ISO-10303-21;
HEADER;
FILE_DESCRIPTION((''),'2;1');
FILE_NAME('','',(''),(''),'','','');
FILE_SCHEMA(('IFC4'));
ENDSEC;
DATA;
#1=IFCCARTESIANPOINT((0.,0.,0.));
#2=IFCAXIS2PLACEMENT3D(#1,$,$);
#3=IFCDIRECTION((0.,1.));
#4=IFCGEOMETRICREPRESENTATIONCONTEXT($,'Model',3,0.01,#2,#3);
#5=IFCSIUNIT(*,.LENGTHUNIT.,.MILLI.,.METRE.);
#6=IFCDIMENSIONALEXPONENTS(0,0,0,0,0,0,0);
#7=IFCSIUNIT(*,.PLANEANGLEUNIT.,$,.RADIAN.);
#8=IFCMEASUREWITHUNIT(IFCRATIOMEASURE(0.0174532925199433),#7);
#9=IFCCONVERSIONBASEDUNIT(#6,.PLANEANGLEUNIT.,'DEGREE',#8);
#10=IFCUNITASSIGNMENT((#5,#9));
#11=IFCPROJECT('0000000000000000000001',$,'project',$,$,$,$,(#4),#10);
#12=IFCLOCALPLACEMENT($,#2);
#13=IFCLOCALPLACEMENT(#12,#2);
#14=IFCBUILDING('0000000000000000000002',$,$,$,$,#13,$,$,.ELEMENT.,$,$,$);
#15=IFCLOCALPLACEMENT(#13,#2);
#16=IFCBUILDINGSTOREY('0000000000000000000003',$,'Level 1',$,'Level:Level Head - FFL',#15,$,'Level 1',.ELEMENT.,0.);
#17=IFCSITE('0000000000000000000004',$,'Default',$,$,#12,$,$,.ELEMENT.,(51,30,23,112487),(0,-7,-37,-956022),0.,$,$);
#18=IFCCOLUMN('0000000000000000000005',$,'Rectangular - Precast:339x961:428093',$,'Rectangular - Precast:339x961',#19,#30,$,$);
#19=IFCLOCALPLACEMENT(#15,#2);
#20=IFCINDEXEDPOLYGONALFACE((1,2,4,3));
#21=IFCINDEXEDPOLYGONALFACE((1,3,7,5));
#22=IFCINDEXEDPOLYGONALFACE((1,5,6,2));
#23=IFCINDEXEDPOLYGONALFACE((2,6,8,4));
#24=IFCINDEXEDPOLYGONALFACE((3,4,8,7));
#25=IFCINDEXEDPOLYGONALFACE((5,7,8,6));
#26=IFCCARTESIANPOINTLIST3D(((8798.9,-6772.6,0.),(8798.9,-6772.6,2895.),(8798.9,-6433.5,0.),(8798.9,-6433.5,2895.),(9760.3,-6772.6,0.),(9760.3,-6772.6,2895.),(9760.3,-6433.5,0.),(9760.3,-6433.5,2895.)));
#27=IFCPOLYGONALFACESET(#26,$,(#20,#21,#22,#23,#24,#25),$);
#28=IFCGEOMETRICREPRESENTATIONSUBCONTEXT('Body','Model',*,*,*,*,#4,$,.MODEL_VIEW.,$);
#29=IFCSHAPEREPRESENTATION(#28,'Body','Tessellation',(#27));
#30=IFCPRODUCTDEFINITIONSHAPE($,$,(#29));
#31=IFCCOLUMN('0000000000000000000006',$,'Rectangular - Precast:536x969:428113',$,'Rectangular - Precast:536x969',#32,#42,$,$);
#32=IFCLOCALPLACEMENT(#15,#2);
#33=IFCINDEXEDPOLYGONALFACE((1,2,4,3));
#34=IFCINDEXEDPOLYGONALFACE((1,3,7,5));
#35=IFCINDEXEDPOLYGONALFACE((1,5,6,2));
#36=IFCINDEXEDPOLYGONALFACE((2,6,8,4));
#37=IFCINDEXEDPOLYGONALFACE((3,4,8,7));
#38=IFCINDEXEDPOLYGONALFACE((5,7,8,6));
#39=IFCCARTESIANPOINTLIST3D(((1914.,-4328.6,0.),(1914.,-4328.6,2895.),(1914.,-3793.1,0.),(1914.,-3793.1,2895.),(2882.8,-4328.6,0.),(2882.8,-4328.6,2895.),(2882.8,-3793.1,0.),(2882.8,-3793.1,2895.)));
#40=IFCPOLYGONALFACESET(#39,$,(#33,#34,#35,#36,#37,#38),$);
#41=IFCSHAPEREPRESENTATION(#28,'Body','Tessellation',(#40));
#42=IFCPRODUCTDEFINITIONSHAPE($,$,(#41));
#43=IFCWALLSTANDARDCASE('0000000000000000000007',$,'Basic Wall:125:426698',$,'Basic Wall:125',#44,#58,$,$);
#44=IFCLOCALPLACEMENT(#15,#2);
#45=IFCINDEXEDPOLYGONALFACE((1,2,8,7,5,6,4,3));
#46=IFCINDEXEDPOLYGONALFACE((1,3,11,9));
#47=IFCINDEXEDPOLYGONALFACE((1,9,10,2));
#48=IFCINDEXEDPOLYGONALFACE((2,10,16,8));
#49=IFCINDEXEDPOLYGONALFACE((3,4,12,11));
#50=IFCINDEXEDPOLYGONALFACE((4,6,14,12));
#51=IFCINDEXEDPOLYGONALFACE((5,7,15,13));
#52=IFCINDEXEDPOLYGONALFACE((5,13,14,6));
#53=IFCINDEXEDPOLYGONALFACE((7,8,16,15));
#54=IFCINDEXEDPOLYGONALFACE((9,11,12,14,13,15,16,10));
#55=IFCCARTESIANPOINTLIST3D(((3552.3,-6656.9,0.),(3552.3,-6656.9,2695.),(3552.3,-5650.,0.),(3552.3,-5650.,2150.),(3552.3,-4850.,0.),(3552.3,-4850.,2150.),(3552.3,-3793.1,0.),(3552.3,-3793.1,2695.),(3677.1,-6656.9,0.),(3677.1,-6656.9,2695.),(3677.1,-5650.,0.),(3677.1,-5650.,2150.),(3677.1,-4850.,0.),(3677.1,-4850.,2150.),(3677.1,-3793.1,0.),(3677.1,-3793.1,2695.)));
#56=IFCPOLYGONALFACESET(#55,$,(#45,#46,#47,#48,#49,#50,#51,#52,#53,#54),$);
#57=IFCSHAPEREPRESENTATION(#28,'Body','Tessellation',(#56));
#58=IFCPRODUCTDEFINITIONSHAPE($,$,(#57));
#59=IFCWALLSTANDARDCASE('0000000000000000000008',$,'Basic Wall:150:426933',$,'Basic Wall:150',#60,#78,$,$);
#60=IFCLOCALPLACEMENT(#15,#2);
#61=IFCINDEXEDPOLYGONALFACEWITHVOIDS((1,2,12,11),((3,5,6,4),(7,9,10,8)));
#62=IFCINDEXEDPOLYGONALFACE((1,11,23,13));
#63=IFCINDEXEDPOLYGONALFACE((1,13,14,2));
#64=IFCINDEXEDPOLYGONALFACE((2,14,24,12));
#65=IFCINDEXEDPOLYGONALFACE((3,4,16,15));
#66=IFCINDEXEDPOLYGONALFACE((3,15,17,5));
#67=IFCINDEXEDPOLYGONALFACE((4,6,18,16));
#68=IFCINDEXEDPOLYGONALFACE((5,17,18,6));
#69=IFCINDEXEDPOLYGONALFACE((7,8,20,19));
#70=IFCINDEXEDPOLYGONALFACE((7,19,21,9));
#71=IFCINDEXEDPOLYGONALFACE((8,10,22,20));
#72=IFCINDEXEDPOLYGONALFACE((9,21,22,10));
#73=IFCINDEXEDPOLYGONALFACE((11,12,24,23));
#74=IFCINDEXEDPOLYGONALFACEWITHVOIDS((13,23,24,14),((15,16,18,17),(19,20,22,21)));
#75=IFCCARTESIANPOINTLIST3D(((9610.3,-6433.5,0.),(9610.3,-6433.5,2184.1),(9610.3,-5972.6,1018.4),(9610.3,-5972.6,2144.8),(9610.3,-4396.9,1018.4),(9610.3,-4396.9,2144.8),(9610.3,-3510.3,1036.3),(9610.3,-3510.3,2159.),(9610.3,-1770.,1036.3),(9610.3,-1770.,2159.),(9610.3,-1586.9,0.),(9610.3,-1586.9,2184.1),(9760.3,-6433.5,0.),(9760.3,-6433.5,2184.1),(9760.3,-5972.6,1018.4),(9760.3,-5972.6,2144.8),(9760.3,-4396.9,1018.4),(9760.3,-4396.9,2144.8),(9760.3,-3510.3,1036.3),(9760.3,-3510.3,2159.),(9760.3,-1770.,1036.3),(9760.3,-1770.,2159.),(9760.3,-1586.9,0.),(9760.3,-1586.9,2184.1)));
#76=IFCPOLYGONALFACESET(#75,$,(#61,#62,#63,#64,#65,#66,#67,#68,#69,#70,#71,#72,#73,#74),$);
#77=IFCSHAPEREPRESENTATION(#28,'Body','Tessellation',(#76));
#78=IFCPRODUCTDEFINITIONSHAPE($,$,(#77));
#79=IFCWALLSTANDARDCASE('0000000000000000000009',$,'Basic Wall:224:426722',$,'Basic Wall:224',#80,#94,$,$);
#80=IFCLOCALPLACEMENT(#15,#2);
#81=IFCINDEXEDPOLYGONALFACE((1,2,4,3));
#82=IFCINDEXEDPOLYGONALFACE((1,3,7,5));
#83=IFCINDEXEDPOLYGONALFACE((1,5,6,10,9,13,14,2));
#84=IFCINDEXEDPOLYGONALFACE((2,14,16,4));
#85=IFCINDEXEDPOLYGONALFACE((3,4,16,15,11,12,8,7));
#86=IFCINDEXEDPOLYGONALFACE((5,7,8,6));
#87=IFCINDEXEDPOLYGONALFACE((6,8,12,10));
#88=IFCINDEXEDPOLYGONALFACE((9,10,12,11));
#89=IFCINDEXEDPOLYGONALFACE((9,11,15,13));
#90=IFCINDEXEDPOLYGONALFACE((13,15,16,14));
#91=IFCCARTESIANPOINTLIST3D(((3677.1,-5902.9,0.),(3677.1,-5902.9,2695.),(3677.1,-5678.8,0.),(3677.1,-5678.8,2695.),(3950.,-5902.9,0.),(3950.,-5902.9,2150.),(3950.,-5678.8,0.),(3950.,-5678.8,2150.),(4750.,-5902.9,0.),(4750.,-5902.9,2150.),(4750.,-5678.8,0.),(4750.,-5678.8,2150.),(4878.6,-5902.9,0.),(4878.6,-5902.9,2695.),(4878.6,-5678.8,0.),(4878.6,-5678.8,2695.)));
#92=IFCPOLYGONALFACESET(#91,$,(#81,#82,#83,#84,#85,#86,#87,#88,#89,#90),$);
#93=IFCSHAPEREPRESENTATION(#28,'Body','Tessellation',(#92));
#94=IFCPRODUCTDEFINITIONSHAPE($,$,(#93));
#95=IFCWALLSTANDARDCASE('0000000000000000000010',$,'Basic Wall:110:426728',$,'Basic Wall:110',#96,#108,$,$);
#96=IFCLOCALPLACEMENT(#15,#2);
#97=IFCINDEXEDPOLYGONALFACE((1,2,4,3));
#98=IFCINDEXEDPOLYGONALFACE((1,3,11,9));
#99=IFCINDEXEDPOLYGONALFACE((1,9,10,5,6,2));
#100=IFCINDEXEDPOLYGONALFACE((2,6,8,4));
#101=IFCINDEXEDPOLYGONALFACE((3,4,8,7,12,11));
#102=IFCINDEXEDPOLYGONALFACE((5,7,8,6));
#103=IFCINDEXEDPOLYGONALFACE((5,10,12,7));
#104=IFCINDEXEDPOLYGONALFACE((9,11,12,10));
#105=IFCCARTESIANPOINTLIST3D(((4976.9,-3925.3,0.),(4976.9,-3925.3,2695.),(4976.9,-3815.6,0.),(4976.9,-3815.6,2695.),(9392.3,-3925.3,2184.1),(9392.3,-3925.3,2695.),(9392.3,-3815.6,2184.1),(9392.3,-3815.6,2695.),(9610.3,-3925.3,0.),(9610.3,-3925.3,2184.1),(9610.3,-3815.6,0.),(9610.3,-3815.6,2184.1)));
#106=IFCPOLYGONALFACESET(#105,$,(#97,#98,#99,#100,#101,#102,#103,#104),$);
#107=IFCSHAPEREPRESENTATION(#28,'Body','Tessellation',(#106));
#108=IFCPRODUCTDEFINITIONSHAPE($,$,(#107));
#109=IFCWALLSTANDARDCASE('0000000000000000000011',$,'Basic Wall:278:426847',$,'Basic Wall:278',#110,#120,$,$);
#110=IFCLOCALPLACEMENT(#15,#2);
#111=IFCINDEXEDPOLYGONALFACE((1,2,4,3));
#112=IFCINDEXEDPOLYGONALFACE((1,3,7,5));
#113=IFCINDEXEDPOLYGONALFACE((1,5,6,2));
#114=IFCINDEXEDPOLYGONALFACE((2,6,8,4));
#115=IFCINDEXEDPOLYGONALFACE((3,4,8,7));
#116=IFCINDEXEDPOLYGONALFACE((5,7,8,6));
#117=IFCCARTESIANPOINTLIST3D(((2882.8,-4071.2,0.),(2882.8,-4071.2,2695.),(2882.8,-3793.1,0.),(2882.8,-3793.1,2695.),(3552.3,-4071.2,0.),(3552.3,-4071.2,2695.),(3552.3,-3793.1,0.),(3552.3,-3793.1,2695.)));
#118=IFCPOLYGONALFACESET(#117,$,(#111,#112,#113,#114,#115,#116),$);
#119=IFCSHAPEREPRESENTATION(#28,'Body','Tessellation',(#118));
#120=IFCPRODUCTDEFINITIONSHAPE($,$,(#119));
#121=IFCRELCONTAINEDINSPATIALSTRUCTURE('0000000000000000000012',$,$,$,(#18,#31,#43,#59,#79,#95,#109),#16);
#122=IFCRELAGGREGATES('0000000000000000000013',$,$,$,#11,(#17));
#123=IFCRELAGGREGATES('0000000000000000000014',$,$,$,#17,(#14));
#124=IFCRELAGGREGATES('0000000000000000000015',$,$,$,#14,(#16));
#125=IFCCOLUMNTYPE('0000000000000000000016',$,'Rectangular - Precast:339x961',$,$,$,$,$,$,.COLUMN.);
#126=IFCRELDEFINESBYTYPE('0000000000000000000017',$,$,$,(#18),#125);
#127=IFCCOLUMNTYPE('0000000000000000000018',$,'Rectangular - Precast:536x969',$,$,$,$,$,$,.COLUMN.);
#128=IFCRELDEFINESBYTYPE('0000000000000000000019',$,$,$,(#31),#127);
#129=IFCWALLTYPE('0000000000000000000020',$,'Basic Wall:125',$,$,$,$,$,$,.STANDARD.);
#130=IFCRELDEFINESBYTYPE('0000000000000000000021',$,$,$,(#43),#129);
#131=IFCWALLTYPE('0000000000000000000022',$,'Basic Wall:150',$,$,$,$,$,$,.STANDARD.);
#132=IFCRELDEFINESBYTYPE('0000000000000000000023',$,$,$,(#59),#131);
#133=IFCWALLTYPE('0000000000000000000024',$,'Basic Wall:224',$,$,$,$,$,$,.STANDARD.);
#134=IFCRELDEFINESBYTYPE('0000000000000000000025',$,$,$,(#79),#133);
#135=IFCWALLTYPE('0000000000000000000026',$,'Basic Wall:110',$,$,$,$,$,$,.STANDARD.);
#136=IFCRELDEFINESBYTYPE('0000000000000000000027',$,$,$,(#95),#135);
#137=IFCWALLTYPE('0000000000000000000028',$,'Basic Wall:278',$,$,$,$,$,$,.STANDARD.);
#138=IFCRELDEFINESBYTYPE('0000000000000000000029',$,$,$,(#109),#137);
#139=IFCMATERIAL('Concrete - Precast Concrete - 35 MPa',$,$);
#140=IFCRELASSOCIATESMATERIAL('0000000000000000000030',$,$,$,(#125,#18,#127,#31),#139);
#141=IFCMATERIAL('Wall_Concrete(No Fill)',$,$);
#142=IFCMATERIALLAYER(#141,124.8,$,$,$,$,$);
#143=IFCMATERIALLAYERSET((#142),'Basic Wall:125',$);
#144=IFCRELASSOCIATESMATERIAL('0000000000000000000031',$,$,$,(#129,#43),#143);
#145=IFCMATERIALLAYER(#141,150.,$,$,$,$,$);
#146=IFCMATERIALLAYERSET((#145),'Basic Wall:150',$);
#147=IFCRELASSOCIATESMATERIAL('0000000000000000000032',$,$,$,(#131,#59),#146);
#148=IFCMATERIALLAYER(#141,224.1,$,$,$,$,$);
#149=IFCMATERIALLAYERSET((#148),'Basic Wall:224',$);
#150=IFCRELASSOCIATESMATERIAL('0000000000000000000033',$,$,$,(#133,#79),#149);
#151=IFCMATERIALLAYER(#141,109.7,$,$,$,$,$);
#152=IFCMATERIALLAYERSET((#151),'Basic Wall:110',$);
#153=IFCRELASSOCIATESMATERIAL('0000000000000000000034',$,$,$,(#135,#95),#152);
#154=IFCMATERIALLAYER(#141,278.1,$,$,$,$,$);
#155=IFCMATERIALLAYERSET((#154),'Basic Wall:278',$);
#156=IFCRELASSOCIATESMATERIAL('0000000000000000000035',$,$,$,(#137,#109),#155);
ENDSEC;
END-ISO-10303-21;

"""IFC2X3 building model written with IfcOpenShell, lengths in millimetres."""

from ifc_helpers import new_model, entity, si_unit, converted_unit, direction, frame, frame_2d, origin, origin_2d_with_axis, place, context, subcontext, project, spatial, rectangle, extrude, source, transform, mapped, material, layer, layer_set, layer_usage, type_object, type_shapes, element, save


model = new_model("IFC2X3")

# Units and contexts
model_context = context("Model", 3, precision=0.01, world=origin(), true_north=direction((0.0, 1.0)))
body_context = subcontext(model_context, "Body", "Model", "MODEL_VIEW")
ifc_project = project(units=[si_unit("LENGTHUNIT", "METRE", prefix="MILLI"), converted_unit("PLANEANGLEUNIT", "DEGREE", entity("IfcRatioMeasure", 0.0174532925199433), si_unit("PLANEANGLEUNIT", "RADIAN"), dimensions=[0, 0, 0, 0, 0, 0, 0])], contexts=[model_context])

# Site, building, storey
site_placement = place(None, origin())
site = spatial("IfcSite", under=ifc_project, at=site_placement, Name="Default", CompositionType="ELEMENT", RefLatitude=(51, 30, 23, 112487), RefLongitude=(0, -7, -37, -956022), RefElevation=0.0)
building_placement = place(site_placement, origin())
building = spatial("IfcBuilding", under=site, at=building_placement, CompositionType="ELEMENT")
storey_placement = place(building_placement, origin())
storey = spatial("IfcBuildingStorey", under=building, at=storey_placement, Name="Level 1", ObjectType="Level:Level Head - FFL", LongName="Level 1", CompositionType="ELEMENT", Elevation=0.0)

# Columns
ifc_material_1 = material(Name="Concrete - Precast Concrete - 35 MPa")
column_type_1 = type_object("IfcColumnType", Name="Rectangular - Precast:339x961", PredefinedType="COLUMN", material=ifc_material_1)
shared_shape_1 = source(origin(), body_context, "Body", "SweptSolid", [
    extrude(rectangle(XDim=961.4, YDim=339.0, at=frame_2d((0.0, 0.0), x_axis=(1.0, 0.0))), frame((0.0, 0.0, 0.0), z_axis=(0.0, 0.0, 1.0), x_axis=(0.0, -1.0, 0.0)), (0.0, 0.0, 1.0), 2895.0),
])
type_shapes(column_type_1, [shared_shape_1])
column_1_placement = place(storey_placement, frame((9279.6, -6603.1, 0.0), z_axis=(0.0, 0.0, 1.0), x_axis=(-0.000004, 1.0, 0.0)))
element("IfcColumn", 1, at=column_1_placement, inside=storey, type_object=column_type_1, material=ifc_material_1, Name="Rectangular - Precast:339x961:428093", ObjectType="Rectangular - Precast:339x961", context=body_context, shape_type="MappedRepresentation", body=[
    mapped(shared_shape_1, transform((0.0, 0.0, 0.0), scale=1.0)),
])
column_type_2 = type_object("IfcColumnType", Name="Rectangular - Precast:536x969", PredefinedType="COLUMN", material=ifc_material_1)
shared_shape_2 = source(origin(), body_context, "Body", "SweptSolid", [
    extrude(rectangle(XDim=968.8, YDim=535.5, at=frame_2d((0.0, 0.0), x_axis=(1.0, 0.0))), frame((0.0, 0.0, 0.0), z_axis=(0.0, 0.0, 1.0), x_axis=(0.0, -1.0, 0.0)), (0.0, 0.0, 1.0), 2895.0),
])
type_shapes(column_type_2, [shared_shape_2])
column_2_placement = place(storey_placement, frame((2398.4, -4060.9, 0.0), z_axis=(0.0, 0.0, 1.0), x_axis=(-0.000004, 1.0, 0.0)))
element("IfcColumn", 2, at=column_2_placement, inside=storey, type_object=column_type_2, material=ifc_material_1, Name="Rectangular - Precast:536x969:428113", ObjectType="Rectangular - Precast:536x969", context=body_context, shape_type="MappedRepresentation", body=[
    mapped(shared_shape_2, transform((0.0, 0.0, 0.0), scale=1.0)),
])

# Shared definitions
ifc_material_2 = material(Name="Wall_Concrete(No Fill)")

# Wall, opening
ifc_layer_1 = layer(ifc_material_2, 124.8)
ifc_layer_set_1 = layer_set([ifc_layer_1], Name="Basic Wall:125")
ifc_layer_usage_1 = layer_usage(ifc_layer_set_1, "AXIS2", "NEGATIVE", 62.4)
wall_type_1 = type_object("IfcWallType", Name="Basic Wall:125", PredefinedType="STANDARD", material=ifc_layer_set_1)
wall_1_placement = place(storey_placement, frame((3614.7, -6656.9, 0.0), z_axis=(0.0, 0.0, 1.0), x_axis=(0.0, 1.0, 0.0)))
wall_1 = element("IfcWallStandardCase", 3, at=wall_1_placement, inside=storey, type_object=wall_type_1, material=ifc_layer_usage_1, Name="Basic Wall:125:426698", ObjectType="Basic Wall:125", context=body_context, shape_type="SweptSolid", body=[
    extrude(rectangle(XDim=2863.8, YDim=124.8, at=frame_2d((1431.9, 0.0), x_axis=(-1.0, 0.0))), origin(), (0.0, 0.0, 1.0), 2695.0),
])
opening_1_placement = place(wall_1_placement, origin())
element("IfcOpeningElement", 4, at=opening_1_placement, cuts=wall_1, ObjectType="Opening", context=body_context, shape_type="SweptSolid", body=[
    extrude(rectangle(XDim=2150.0, YDim=800.0, at=frame_2d((0.0, 0.0), x_axis=(1.0, 0.0))), frame((1406.9, -62.4, 1075.0), z_axis=(0.0, 1.0, 0.0), x_axis=(0.0, 0.0, -1.0)), (0.0, 0.0, 1.0), 124.8),
])

# Wall, openings
ifc_layer_2 = layer(ifc_material_2, 150.0)
ifc_layer_set_2 = layer_set([ifc_layer_2], Name="Basic Wall:150")
wall_type_2 = type_object("IfcWallType", Name="Basic Wall:150", PredefinedType="STANDARD", material=ifc_layer_set_2)
ifc_layer_usage_2 = layer_usage(ifc_layer_set_2, "AXIS2", "NEGATIVE", 75.0)
wall_2_placement = place(storey_placement, frame((9685.3, -6433.5, 0.0), z_axis=(0.0, 0.0, 1.0), x_axis=(0.0, 1.0, 0.0)))
wall_2 = element("IfcWallStandardCase", 5, at=wall_2_placement, inside=storey, type_object=wall_type_2, material=ifc_layer_usage_2, Name="Basic Wall:150:426933", ObjectType="Basic Wall:150", context=body_context, shape_type="SweptSolid", body=[
    extrude(rectangle(XDim=4846.6, YDim=150.0, at=frame_2d((2423.3, 0.0), x_axis=(-1.0, 0.0))), origin(), (0.0, 0.0, 1.0), 2184.1),
])
opening_2_placement = place(wall_2_placement, origin())
element("IfcOpeningElement", 6, at=opening_2_placement, cuts=wall_2, ObjectType="Opening", context=body_context, shape_type="SweptSolid", body=[
    extrude(rectangle(XDim=710.9, YDim=4846.6, at=origin_2d_with_axis()), frame((2423.3, -75.0, 2539.6), z_axis=(0.0, 1.0, 0.0), x_axis=(0.0, 0.0, -1.0)), (0.0, 0.0, 1.0), 150.0),
])
opening_3_placement = place(wall_2_placement, origin())
element("IfcOpeningElement", 7, at=opening_3_placement, cuts=wall_2, ObjectType="Opening", context=body_context, shape_type="SweptSolid", body=[
    extrude(rectangle(XDim=1122.7, YDim=1740.3, at=origin_2d_with_axis()), frame((3793.4, -75.0, 1597.7), z_axis=(0.0, 1.0, 0.0), x_axis=(0.0, 0.0, -1.0)), (0.0, 0.0, 1.0), 150.0),
])
opening_4_placement = place(wall_2_placement, origin())
element("IfcOpeningElement", 8, at=opening_4_placement, cuts=wall_2, ObjectType="Opening", context=body_context, shape_type="SweptSolid", body=[
    extrude(rectangle(XDim=1126.4, YDim=1575.7, at=frame_2d((0.0, 0.0), x_axis=(1.0, 0.0))), frame((1248.8, -75.0, 1581.6), z_axis=(0.0, 1.0, 0.0), x_axis=(0.0, 0.0, -1.0)), (0.0, 0.0, 1.0), 150.0),
])

# Walls, openings
ifc_layer_3 = layer(ifc_material_2, 224.1)
ifc_layer_set_3 = layer_set([ifc_layer_3], Name="Basic Wall:224")
ifc_layer_usage_3 = layer_usage(ifc_layer_set_3, "AXIS2", "NEGATIVE", 112.0)
wall_type_3 = type_object("IfcWallType", Name="Basic Wall:224", PredefinedType="STANDARD", material=ifc_layer_set_3)
wall_3_placement = place(storey_placement, frame((3677.1, -5790.9, 0.0)))
wall_3 = element("IfcWallStandardCase", 9, at=wall_3_placement, inside=storey, type_object=wall_type_3, material=ifc_layer_usage_3, Name="Basic Wall:224:426722", ObjectType="Basic Wall:224", context=body_context, shape_type="SweptSolid", body=[
    extrude(rectangle(XDim=1201.5, YDim=224.1, at=frame_2d((600.7, 0.0), x_axis=(-1.0, 0.0))), origin(), (0.0, 0.0, 1.0), 2695.0),
])
opening_5_placement = place(wall_3_placement, origin())
element("IfcOpeningElement", 10, at=opening_5_placement, cuts=wall_3, ObjectType="Opening", context=body_context, shape_type="SweptSolid", body=[
    extrude(rectangle(XDim=2150.0, YDim=800.0, at=frame_2d((0.0, 0.0), x_axis=(1.0, 0.0))), frame((672.9, -112.0, 1075.0), z_axis=(0.0, 1.0, 0.0), x_axis=(0.0, 0.0, -1.0)), (0.0, 0.0, 1.0), 224.1),
])
ifc_layer_4 = layer(ifc_material_2, 109.7)
ifc_layer_set_4 = layer_set([ifc_layer_4], Name="Basic Wall:110")
ifc_layer_usage_4 = layer_usage(ifc_layer_set_4, "AXIS2", "NEGATIVE", 54.8)
wall_type_4 = type_object("IfcWallType", Name="Basic Wall:110", PredefinedType="STANDARD", material=ifc_layer_set_4)
wall_4_placement = place(storey_placement, frame((4976.9, -3870.5, 0.0)))
wall_4 = element("IfcWallStandardCase", 11, at=wall_4_placement, inside=storey, type_object=wall_type_4, material=ifc_layer_usage_4, Name="Basic Wall:110:426728", ObjectType="Basic Wall:110", context=body_context, shape_type="SweptSolid", body=[
    extrude(rectangle(XDim=4633.4, YDim=109.7, at=frame_2d((2316.7, 0.0), x_axis=(-1.0, 0.0))), origin(), (0.0, 0.0, 1.0), 2695.0),
])
opening_6_placement = place(wall_4_placement, origin())
element("IfcOpeningElement", 12, at=opening_6_placement, cuts=wall_4, ObjectType="Opening", context=body_context, shape_type="SweptSolid", body=[
    extrude(rectangle(XDim=710.9, YDim=218.0, at=frame_2d((0.0, 0.0), x_axis=(1.0, 0.0))), frame((4524.4, -54.8, 2539.6), z_axis=(0.0, 1.0, 0.0), x_axis=(0.0, 0.0, -1.0)), (0.0, 0.0, 1.0), 109.7),
])

# Wall
ifc_layer_5 = layer(ifc_material_2, 278.1)
ifc_layer_set_5 = layer_set([ifc_layer_5], Name="Basic Wall:278")
ifc_layer_usage_5 = layer_usage(ifc_layer_set_5, "AXIS2", "NEGATIVE", 139.1)
wall_type_5 = type_object("IfcWallType", Name="Basic Wall:278", PredefinedType="STANDARD", material=ifc_layer_set_5)
wall_5_placement = place(storey_placement, frame((2882.8, -3932.2, 0.0)))
element("IfcWallStandardCase", 13, at=wall_5_placement, inside=storey, type_object=wall_type_5, material=ifc_layer_usage_5, Name="Basic Wall:278:426847", ObjectType="Basic Wall:278", context=body_context, shape_type="SweptSolid", body=[
    extrude(rectangle(XDim=669.5, YDim=278.1, at=frame_2d((334.7, 0.0), x_axis=(-1.0, 0.0))), origin(), (0.0, 0.0, 1.0), 2695.0),
])

save(model, "model.ifc")
